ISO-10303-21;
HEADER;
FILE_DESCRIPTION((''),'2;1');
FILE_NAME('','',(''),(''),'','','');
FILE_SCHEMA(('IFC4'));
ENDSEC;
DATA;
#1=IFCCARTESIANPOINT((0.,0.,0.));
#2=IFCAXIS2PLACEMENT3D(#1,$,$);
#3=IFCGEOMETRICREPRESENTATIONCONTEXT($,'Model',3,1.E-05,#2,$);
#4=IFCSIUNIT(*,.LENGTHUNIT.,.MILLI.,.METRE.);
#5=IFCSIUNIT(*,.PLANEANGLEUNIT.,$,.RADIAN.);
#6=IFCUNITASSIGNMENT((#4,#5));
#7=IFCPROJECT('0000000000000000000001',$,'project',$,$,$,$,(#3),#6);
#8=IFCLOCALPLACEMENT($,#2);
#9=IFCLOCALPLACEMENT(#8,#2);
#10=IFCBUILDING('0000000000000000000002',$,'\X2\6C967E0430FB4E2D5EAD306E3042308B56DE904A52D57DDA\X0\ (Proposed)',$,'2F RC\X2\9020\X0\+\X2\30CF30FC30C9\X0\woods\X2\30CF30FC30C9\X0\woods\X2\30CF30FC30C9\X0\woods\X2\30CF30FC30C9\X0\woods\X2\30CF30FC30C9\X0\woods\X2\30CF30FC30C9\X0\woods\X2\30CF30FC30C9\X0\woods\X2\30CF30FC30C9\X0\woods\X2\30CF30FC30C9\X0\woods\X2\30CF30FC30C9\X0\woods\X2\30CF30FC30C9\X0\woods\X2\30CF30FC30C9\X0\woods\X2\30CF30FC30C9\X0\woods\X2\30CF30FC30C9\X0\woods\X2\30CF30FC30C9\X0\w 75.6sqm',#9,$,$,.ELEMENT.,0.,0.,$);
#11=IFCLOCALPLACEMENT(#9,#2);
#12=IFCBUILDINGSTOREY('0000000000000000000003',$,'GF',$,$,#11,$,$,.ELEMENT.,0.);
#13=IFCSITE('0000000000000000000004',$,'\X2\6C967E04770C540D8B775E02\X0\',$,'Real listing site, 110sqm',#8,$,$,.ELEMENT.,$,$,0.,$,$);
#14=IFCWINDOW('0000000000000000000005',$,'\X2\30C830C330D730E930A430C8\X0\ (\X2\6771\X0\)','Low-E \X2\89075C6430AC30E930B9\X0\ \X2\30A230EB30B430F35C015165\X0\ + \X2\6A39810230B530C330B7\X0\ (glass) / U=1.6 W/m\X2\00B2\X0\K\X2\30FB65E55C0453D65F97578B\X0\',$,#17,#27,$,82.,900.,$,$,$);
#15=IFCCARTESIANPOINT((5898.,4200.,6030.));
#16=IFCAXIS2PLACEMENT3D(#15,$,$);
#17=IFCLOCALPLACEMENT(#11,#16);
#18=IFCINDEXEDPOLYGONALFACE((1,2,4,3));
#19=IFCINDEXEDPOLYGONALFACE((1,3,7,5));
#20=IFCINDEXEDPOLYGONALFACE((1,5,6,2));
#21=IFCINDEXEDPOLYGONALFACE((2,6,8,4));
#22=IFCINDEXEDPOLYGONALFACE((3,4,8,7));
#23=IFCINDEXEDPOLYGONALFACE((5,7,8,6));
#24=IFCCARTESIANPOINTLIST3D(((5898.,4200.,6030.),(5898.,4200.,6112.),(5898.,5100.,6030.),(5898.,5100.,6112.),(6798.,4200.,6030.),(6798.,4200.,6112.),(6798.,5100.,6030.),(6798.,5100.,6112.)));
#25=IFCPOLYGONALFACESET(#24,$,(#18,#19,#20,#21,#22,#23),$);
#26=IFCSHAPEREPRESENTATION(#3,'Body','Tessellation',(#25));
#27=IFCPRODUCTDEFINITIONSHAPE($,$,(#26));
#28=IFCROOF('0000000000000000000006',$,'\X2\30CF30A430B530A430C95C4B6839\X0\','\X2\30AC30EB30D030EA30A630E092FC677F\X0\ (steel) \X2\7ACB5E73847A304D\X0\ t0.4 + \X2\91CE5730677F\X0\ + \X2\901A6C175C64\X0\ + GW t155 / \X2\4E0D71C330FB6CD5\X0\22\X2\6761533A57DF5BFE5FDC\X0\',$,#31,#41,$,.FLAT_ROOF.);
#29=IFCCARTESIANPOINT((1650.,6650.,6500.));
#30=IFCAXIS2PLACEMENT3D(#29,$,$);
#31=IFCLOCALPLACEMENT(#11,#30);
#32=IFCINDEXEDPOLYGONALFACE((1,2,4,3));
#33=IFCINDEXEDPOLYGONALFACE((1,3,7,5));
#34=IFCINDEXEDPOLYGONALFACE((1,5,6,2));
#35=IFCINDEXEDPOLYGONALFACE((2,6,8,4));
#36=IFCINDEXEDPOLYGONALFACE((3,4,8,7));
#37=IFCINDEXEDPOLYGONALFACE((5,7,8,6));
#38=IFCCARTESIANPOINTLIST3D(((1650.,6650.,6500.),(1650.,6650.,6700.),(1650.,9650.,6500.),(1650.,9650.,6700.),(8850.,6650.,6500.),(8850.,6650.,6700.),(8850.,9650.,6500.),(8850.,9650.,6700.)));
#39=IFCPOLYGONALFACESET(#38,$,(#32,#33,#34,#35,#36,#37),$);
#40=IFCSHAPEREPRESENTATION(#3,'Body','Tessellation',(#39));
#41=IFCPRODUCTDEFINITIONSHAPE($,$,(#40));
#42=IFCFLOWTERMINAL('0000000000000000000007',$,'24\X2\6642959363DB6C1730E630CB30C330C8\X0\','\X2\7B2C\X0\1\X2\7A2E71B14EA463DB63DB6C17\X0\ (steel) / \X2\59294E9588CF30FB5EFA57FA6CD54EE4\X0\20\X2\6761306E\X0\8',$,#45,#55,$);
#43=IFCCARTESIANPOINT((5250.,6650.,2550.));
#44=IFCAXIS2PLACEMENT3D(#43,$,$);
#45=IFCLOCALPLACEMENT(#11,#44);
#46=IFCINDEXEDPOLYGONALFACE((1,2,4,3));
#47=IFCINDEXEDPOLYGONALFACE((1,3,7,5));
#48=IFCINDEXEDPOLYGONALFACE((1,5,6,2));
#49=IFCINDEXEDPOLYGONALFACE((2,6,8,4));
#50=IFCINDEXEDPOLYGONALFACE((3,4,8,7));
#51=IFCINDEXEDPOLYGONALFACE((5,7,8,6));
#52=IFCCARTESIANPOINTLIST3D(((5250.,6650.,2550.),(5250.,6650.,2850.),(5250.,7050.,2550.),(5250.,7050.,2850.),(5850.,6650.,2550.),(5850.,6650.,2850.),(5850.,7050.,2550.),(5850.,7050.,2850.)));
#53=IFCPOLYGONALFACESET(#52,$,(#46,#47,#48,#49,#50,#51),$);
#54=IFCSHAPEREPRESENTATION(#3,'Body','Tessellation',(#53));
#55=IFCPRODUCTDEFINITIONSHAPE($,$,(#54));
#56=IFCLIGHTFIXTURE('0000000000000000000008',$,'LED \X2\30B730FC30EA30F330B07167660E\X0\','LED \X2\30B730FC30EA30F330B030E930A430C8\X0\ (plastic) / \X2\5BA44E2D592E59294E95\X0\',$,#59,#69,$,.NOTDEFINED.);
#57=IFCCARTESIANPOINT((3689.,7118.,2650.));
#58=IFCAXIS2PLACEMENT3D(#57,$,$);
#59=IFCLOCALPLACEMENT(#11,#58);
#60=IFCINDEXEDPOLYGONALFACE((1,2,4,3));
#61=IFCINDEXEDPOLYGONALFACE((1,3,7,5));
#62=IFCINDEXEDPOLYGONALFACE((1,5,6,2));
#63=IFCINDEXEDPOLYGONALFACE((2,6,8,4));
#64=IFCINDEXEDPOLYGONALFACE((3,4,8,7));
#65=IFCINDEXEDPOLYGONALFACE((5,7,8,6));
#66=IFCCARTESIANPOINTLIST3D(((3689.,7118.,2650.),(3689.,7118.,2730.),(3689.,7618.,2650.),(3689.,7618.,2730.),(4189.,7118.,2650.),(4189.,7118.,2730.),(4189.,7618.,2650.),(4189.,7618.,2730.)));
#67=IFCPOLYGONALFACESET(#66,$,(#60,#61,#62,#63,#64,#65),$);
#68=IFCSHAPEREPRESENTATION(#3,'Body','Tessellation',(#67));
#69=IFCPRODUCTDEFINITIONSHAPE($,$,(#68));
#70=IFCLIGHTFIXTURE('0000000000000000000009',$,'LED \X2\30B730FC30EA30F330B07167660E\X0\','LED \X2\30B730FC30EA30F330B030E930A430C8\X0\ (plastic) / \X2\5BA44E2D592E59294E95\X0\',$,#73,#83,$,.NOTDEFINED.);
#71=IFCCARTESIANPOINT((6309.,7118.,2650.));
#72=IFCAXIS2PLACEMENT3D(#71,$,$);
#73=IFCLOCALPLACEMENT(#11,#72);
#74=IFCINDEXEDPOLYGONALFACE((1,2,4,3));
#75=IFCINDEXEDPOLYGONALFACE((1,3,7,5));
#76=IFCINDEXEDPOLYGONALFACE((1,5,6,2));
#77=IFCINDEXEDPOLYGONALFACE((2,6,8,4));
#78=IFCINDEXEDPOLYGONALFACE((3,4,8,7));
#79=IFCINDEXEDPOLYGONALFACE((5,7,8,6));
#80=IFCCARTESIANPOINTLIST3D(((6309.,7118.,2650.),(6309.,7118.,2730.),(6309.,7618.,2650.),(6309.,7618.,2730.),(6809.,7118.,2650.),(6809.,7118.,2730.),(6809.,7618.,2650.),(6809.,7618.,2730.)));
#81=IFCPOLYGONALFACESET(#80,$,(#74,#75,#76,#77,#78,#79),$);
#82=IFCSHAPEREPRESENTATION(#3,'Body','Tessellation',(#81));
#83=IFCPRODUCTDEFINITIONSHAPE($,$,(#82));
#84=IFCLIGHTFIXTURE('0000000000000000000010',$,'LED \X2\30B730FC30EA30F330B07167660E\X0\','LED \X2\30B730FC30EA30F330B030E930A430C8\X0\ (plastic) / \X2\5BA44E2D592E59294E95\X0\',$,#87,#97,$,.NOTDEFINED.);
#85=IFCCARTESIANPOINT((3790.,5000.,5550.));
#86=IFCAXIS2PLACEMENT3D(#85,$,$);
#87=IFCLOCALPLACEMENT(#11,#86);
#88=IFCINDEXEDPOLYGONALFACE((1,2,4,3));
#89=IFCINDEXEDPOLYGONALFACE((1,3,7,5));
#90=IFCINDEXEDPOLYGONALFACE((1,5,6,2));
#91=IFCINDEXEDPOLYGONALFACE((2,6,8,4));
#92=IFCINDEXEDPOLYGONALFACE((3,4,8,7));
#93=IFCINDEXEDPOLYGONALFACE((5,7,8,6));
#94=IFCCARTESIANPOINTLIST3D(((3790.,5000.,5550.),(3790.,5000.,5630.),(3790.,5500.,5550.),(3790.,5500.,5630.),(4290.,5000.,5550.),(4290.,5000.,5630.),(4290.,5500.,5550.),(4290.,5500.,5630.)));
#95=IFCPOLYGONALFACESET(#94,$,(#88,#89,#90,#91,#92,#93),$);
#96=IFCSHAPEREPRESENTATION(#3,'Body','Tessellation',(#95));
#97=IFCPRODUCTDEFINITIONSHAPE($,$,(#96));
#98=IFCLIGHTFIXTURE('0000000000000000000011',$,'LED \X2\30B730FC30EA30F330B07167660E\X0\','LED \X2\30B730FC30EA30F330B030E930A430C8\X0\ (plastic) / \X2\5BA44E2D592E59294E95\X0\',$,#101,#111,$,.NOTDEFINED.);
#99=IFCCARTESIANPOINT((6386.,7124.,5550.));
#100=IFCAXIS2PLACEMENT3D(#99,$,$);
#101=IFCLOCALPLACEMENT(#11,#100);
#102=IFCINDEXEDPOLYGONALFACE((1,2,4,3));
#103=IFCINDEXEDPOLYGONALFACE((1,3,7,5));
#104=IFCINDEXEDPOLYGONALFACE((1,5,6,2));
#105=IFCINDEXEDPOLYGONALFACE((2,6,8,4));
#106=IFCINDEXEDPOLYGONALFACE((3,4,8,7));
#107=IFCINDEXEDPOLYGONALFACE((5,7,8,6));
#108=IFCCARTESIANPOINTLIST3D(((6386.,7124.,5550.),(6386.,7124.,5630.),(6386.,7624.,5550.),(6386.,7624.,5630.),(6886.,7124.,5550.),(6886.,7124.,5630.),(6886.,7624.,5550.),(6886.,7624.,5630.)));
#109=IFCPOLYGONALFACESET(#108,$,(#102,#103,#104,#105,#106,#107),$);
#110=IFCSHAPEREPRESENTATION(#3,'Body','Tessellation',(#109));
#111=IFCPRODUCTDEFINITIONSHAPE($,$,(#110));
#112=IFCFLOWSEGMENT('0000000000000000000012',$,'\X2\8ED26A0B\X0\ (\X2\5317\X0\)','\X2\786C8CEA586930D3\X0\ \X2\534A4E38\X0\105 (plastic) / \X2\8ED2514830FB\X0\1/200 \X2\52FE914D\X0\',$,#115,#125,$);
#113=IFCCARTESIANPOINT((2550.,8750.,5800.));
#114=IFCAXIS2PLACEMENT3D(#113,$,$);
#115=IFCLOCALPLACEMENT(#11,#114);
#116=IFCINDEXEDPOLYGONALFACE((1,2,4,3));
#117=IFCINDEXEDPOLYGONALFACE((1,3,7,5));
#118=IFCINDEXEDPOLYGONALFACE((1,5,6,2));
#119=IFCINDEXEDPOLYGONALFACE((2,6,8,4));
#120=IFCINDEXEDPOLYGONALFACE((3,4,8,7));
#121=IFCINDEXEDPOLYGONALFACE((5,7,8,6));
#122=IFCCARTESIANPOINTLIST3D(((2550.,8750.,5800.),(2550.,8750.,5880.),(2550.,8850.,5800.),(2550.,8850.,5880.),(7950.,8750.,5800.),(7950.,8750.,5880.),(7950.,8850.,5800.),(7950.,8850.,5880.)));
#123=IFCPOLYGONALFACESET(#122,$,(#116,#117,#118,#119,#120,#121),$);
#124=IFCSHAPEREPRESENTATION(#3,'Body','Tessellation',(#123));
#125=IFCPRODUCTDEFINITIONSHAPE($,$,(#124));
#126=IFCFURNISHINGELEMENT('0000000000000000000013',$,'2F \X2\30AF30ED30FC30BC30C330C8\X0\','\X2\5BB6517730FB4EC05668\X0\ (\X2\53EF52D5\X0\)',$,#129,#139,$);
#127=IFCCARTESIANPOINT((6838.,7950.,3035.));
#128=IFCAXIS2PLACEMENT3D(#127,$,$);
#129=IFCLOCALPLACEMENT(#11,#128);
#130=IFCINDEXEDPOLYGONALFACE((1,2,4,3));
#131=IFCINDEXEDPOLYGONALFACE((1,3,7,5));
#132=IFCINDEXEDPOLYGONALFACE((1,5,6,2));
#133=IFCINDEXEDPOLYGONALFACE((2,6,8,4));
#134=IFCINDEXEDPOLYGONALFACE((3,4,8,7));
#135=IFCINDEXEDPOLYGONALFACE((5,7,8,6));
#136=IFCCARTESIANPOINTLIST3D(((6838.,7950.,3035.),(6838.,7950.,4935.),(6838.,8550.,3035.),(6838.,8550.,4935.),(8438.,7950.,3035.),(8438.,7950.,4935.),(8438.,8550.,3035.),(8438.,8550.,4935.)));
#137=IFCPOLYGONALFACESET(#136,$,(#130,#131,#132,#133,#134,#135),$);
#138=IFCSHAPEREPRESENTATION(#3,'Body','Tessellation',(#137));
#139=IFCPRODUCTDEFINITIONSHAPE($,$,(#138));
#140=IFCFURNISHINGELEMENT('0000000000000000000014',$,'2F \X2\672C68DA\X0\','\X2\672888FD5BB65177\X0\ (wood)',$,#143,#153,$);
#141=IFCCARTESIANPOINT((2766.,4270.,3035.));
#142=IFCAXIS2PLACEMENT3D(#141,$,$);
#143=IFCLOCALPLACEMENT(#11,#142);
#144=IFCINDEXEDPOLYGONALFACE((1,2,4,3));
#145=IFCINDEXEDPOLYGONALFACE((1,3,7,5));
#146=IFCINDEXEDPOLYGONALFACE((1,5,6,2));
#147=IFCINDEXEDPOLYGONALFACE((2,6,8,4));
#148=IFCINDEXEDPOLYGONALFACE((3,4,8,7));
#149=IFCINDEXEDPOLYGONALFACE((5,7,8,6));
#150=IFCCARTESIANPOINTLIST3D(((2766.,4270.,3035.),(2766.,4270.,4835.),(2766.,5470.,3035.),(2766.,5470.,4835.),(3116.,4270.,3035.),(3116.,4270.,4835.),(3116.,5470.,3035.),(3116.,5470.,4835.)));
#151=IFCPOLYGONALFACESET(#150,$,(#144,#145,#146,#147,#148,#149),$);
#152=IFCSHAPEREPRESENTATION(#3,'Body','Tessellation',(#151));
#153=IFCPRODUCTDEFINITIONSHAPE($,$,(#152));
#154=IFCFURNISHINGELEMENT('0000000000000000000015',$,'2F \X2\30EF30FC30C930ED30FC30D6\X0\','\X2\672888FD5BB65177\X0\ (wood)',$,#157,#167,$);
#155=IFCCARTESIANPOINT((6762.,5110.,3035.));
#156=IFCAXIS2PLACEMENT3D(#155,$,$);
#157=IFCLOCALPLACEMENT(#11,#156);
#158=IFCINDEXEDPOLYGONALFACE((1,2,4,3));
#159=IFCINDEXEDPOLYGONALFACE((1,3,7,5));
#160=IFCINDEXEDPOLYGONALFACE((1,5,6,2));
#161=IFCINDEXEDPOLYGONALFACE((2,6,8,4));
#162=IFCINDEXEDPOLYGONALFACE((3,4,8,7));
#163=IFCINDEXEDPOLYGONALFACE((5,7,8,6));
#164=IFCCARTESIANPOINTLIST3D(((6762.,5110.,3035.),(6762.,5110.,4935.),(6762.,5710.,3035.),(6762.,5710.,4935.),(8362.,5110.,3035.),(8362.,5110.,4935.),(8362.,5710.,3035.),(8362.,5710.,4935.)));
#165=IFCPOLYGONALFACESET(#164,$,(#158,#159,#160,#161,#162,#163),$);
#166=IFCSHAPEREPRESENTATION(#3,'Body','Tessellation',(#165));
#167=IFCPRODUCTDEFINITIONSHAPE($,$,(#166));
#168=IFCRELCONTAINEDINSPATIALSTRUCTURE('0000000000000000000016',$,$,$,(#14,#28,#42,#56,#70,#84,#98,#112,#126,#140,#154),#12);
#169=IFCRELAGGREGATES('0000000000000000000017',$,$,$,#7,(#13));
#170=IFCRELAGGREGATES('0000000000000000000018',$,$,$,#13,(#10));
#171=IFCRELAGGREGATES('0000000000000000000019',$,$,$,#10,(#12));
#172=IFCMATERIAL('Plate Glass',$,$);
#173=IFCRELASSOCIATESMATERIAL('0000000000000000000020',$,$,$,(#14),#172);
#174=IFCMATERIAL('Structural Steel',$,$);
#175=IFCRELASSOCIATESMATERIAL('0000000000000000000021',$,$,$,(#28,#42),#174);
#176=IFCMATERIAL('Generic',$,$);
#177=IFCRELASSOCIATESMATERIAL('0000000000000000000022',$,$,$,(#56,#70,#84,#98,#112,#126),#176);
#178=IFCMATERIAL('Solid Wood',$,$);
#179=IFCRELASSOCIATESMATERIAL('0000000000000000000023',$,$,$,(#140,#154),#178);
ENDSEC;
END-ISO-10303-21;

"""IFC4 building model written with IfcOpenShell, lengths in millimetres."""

from ifc_helpers import new_model, si_unit, frame, frame_2d, origin, place, context, project, spatial, rectangle, extrude, material, element, save


model = new_model("IFC4")

# Units and contexts
model_context = context("Model", 3, precision=1e-05, world=origin())
ifc_project = project(units=[si_unit("LENGTHUNIT", "METRE", prefix="MILLI"), si_unit("PLANEANGLEUNIT", "RADIAN")], contexts=[model_context])

# Site, building, storey
site_placement = place(None, origin())
site = spatial("IfcSite", under=ifc_project, at=site_placement, Name="沖縄県名護市", ObjectType="Real listing site, 110sqm", CompositionType="ELEMENT", RefElevation=0.0)
building_placement = place(site_placement, origin())
building = spatial("IfcBuilding", under=site, at=building_placement, Name="沖縄・中庭のある回遊動線 (Proposed)", ObjectType="2F RC造+ハードwoodsハードwoodsハードwoodsハードwoodsハードwoodsハードwoodsハードwoodsハードwoodsハードwoodsハードwoodsハードwoodsハードwoodsハードwoodsハードwoodsハードw 75.6sqm", CompositionType="ELEMENT", ElevationOfRefHeight=0.0, ElevationOfTerrain=0.0)
storey_placement = place(building_placement, origin())
storey = spatial("IfcBuildingStorey", under=building, at=storey_placement, Name="GF", CompositionType="ELEMENT", Elevation=0.0)

# Shared definitions
ifc_material_1 = material(Name="Solid Wood")

# Shared definitions
ifc_material_2 = material(Name="Plate Glass")

# Window
window_1_placement = place(storey_placement, frame((5898.0, 4200.0, 6030.0)))
element("IfcWindow", 1, at=window_1_placement, inside=storey, material=ifc_material_2, Name="トップライト (東)", Description="Low-E 複層ガラス アルゴン封入 + 樹脂サッシ (glass) / U=1.6 W/m²K・日射取得型", OverallHeight=82.0, OverallWidth=900.0, context=model_context, shape_type="SweptSolid", body=[
    extrude(rectangle(XDim=900.0, YDim=900.0, at=frame_2d((450.0, 450.0))), frame((5898.0, 4200.0, 6030.0)), (0.0, 0.0, 1.0), 82.0),
])

# Roof
ifc_material_3 = material(Name="Structural Steel")
roof_placement = place(storey_placement, frame((1650.0, 6650.0, 6500.0)))
element("IfcRoof", 2, at=roof_placement, inside=storey, material=ifc_material_3, Name="ハイサイド屋根", Description="ガルバリウム鋼板 (steel) 立平葺き t0.4 + 野地板 + 通気層 + GW t155 / 不燃・法22条区域対応", PredefinedType="FLAT_ROOF", context=model_context, shape_type="SweptSolid", body=[
    extrude(rectangle(XDim=7200.0, YDim=3000.0, at=frame_2d((3600.0, 1500.0))), frame((1650.0, 6650.0, 6500.0)), (0.0, 0.0, 1.0), 200.0),
])

# Flow terminal
flow_terminal_placement = place(storey_placement, frame((5250.0, 6650.0, 2550.0)))
element("IfcFlowTerminal", 3, at=flow_terminal_placement, inside=storey, material=ifc_material_3, Name="24時間換気ユニット", Description="第1種熱交換換気 (steel) / 天井裏・建基法令20条の8", context=model_context, shape_type="SweptSolid", body=[
    extrude(rectangle(XDim=600.0, YDim=400.0, at=frame_2d((300.0, 200.0))), frame((5250.0, 6650.0, 2550.0)), (0.0, 0.0, 1.0), 300.0),
])

# Light fixtures
ifc_material_4 = material(Name="Generic")
light_fixture_1_placement = place(storey_placement, frame((3689.0, 7118.0, 2650.0)))
element("IfcLightFixture", 4, at=light_fixture_1_placement, inside=storey, material=ifc_material_4, Name="LED シーリング照明", Description="LED シーリングライト (plastic) / 室中央天井", PredefinedType="NOTDEFINED", context=model_context, shape_type="SweptSolid", body=[
    extrude(rectangle(XDim=500.0, YDim=500.0, at=frame_2d((250.0, 250.0))), frame((3689.0, 7118.0, 2650.0)), (0.0, 0.0, 1.0), 80.0),
])
light_fixture_2_placement = place(storey_placement, frame((6309.0, 7118.0, 2650.0)))
element("IfcLightFixture", 5, at=light_fixture_2_placement, inside=storey, material=ifc_material_4, Name="LED シーリング照明", Description="LED シーリングライト (plastic) / 室中央天井", PredefinedType="NOTDEFINED", context=model_context, shape_type="SweptSolid", body=[
    extrude(rectangle(XDim=500.0, YDim=500.0, at=frame_2d((250.0, 250.0))), frame((6309.0, 7118.0, 2650.0)), (0.0, 0.0, 1.0), 80.0),
])
light_fixture_3_placement = place(storey_placement, frame((3790.0, 5000.0, 5550.0)))
element("IfcLightFixture", 6, at=light_fixture_3_placement, inside=storey, material=ifc_material_4, Name="LED シーリング照明", Description="LED シーリングライト (plastic) / 室中央天井", PredefinedType="NOTDEFINED", context=model_context, shape_type="SweptSolid", body=[
    extrude(rectangle(XDim=500.0, YDim=500.0, at=frame_2d((250.0, 250.0))), frame((3790.0, 5000.0, 5550.0)), (0.0, 0.0, 1.0), 80.0),
])
light_fixture_4_placement = place(storey_placement, frame((6386.0, 7124.0, 5550.0)))
element("IfcLightFixture", 7, at=light_fixture_4_placement, inside=storey, material=ifc_material_4, Name="LED シーリング照明", Description="LED シーリングライト (plastic) / 室中央天井", PredefinedType="NOTDEFINED", context=model_context, shape_type="SweptSolid", body=[
    extrude(rectangle(XDim=500.0, YDim=500.0, at=frame_2d((250.0, 250.0))), frame((6386.0, 7124.0, 5550.0)), (0.0, 0.0, 1.0), 80.0),
])

# Flow segment
flow_segment_placement = place(storey_placement, frame((2550.0, 8750.0, 5800.0)))
element("IfcFlowSegment", 8, at=flow_segment_placement, inside=storey, material=ifc_material_4, Name="軒樋 (北)", Description="硬質塩ビ 半丸105 (plastic) / 軒先・1/200 勾配", context=model_context, shape_type="SweptSolid", body=[
    extrude(rectangle(XDim=5400.0, YDim=100.0, at=frame_2d((2700.0, 50.0))), frame((2550.0, 8750.0, 5800.0)), (0.0, 0.0, 1.0), 80.0),
])

# Furnishing elements
furnishing_1_placement = place(storey_placement, frame((6838.0, 7950.0, 3035.0)))
element("IfcFurnishingElement", 9, at=furnishing_1_placement, inside=storey, material=ifc_material_4, Name="2F クローゼット", Description="家具・什器 (可動)", context=model_context, shape_type="SweptSolid", body=[
    extrude(rectangle(XDim=1600.0, YDim=600.0, at=frame_2d((800.0, 300.0))), frame((6838.0, 7950.0, 3035.0)), (0.0, 0.0, 1.0), 1900.0),
])
furnishing_2_placement = place(storey_placement, frame((2766.0, 4270.0, 3035.0)))
element("IfcFurnishingElement", 10, at=furnishing_2_placement, inside=storey, material=ifc_material_1, Name="2F 本棚", Description="木製家具 (wood)", context=model_context, shape_type="SweptSolid", body=[
    extrude(rectangle(XDim=350.0, YDim=1200.0, at=frame_2d((175.0, 600.0))), frame((2766.0, 4270.0, 3035.0)), (0.0, 0.0, 1.0), 1800.0),
])
furnishing_3_placement = place(storey_placement, frame((6762.0, 5110.0, 3035.0)))
element("IfcFurnishingElement", 11, at=furnishing_3_placement, inside=storey, material=ifc_material_1, Name="2F ワードローブ", Description="木製家具 (wood)", context=model_context, shape_type="SweptSolid", body=[
    extrude(rectangle(XDim=1600.0, YDim=600.0, at=frame_2d((800.0, 300.0))), frame((6762.0, 5110.0, 3035.0)), (0.0, 0.0, 1.0), 1900.0),
])

save(model, "model.ifc")
